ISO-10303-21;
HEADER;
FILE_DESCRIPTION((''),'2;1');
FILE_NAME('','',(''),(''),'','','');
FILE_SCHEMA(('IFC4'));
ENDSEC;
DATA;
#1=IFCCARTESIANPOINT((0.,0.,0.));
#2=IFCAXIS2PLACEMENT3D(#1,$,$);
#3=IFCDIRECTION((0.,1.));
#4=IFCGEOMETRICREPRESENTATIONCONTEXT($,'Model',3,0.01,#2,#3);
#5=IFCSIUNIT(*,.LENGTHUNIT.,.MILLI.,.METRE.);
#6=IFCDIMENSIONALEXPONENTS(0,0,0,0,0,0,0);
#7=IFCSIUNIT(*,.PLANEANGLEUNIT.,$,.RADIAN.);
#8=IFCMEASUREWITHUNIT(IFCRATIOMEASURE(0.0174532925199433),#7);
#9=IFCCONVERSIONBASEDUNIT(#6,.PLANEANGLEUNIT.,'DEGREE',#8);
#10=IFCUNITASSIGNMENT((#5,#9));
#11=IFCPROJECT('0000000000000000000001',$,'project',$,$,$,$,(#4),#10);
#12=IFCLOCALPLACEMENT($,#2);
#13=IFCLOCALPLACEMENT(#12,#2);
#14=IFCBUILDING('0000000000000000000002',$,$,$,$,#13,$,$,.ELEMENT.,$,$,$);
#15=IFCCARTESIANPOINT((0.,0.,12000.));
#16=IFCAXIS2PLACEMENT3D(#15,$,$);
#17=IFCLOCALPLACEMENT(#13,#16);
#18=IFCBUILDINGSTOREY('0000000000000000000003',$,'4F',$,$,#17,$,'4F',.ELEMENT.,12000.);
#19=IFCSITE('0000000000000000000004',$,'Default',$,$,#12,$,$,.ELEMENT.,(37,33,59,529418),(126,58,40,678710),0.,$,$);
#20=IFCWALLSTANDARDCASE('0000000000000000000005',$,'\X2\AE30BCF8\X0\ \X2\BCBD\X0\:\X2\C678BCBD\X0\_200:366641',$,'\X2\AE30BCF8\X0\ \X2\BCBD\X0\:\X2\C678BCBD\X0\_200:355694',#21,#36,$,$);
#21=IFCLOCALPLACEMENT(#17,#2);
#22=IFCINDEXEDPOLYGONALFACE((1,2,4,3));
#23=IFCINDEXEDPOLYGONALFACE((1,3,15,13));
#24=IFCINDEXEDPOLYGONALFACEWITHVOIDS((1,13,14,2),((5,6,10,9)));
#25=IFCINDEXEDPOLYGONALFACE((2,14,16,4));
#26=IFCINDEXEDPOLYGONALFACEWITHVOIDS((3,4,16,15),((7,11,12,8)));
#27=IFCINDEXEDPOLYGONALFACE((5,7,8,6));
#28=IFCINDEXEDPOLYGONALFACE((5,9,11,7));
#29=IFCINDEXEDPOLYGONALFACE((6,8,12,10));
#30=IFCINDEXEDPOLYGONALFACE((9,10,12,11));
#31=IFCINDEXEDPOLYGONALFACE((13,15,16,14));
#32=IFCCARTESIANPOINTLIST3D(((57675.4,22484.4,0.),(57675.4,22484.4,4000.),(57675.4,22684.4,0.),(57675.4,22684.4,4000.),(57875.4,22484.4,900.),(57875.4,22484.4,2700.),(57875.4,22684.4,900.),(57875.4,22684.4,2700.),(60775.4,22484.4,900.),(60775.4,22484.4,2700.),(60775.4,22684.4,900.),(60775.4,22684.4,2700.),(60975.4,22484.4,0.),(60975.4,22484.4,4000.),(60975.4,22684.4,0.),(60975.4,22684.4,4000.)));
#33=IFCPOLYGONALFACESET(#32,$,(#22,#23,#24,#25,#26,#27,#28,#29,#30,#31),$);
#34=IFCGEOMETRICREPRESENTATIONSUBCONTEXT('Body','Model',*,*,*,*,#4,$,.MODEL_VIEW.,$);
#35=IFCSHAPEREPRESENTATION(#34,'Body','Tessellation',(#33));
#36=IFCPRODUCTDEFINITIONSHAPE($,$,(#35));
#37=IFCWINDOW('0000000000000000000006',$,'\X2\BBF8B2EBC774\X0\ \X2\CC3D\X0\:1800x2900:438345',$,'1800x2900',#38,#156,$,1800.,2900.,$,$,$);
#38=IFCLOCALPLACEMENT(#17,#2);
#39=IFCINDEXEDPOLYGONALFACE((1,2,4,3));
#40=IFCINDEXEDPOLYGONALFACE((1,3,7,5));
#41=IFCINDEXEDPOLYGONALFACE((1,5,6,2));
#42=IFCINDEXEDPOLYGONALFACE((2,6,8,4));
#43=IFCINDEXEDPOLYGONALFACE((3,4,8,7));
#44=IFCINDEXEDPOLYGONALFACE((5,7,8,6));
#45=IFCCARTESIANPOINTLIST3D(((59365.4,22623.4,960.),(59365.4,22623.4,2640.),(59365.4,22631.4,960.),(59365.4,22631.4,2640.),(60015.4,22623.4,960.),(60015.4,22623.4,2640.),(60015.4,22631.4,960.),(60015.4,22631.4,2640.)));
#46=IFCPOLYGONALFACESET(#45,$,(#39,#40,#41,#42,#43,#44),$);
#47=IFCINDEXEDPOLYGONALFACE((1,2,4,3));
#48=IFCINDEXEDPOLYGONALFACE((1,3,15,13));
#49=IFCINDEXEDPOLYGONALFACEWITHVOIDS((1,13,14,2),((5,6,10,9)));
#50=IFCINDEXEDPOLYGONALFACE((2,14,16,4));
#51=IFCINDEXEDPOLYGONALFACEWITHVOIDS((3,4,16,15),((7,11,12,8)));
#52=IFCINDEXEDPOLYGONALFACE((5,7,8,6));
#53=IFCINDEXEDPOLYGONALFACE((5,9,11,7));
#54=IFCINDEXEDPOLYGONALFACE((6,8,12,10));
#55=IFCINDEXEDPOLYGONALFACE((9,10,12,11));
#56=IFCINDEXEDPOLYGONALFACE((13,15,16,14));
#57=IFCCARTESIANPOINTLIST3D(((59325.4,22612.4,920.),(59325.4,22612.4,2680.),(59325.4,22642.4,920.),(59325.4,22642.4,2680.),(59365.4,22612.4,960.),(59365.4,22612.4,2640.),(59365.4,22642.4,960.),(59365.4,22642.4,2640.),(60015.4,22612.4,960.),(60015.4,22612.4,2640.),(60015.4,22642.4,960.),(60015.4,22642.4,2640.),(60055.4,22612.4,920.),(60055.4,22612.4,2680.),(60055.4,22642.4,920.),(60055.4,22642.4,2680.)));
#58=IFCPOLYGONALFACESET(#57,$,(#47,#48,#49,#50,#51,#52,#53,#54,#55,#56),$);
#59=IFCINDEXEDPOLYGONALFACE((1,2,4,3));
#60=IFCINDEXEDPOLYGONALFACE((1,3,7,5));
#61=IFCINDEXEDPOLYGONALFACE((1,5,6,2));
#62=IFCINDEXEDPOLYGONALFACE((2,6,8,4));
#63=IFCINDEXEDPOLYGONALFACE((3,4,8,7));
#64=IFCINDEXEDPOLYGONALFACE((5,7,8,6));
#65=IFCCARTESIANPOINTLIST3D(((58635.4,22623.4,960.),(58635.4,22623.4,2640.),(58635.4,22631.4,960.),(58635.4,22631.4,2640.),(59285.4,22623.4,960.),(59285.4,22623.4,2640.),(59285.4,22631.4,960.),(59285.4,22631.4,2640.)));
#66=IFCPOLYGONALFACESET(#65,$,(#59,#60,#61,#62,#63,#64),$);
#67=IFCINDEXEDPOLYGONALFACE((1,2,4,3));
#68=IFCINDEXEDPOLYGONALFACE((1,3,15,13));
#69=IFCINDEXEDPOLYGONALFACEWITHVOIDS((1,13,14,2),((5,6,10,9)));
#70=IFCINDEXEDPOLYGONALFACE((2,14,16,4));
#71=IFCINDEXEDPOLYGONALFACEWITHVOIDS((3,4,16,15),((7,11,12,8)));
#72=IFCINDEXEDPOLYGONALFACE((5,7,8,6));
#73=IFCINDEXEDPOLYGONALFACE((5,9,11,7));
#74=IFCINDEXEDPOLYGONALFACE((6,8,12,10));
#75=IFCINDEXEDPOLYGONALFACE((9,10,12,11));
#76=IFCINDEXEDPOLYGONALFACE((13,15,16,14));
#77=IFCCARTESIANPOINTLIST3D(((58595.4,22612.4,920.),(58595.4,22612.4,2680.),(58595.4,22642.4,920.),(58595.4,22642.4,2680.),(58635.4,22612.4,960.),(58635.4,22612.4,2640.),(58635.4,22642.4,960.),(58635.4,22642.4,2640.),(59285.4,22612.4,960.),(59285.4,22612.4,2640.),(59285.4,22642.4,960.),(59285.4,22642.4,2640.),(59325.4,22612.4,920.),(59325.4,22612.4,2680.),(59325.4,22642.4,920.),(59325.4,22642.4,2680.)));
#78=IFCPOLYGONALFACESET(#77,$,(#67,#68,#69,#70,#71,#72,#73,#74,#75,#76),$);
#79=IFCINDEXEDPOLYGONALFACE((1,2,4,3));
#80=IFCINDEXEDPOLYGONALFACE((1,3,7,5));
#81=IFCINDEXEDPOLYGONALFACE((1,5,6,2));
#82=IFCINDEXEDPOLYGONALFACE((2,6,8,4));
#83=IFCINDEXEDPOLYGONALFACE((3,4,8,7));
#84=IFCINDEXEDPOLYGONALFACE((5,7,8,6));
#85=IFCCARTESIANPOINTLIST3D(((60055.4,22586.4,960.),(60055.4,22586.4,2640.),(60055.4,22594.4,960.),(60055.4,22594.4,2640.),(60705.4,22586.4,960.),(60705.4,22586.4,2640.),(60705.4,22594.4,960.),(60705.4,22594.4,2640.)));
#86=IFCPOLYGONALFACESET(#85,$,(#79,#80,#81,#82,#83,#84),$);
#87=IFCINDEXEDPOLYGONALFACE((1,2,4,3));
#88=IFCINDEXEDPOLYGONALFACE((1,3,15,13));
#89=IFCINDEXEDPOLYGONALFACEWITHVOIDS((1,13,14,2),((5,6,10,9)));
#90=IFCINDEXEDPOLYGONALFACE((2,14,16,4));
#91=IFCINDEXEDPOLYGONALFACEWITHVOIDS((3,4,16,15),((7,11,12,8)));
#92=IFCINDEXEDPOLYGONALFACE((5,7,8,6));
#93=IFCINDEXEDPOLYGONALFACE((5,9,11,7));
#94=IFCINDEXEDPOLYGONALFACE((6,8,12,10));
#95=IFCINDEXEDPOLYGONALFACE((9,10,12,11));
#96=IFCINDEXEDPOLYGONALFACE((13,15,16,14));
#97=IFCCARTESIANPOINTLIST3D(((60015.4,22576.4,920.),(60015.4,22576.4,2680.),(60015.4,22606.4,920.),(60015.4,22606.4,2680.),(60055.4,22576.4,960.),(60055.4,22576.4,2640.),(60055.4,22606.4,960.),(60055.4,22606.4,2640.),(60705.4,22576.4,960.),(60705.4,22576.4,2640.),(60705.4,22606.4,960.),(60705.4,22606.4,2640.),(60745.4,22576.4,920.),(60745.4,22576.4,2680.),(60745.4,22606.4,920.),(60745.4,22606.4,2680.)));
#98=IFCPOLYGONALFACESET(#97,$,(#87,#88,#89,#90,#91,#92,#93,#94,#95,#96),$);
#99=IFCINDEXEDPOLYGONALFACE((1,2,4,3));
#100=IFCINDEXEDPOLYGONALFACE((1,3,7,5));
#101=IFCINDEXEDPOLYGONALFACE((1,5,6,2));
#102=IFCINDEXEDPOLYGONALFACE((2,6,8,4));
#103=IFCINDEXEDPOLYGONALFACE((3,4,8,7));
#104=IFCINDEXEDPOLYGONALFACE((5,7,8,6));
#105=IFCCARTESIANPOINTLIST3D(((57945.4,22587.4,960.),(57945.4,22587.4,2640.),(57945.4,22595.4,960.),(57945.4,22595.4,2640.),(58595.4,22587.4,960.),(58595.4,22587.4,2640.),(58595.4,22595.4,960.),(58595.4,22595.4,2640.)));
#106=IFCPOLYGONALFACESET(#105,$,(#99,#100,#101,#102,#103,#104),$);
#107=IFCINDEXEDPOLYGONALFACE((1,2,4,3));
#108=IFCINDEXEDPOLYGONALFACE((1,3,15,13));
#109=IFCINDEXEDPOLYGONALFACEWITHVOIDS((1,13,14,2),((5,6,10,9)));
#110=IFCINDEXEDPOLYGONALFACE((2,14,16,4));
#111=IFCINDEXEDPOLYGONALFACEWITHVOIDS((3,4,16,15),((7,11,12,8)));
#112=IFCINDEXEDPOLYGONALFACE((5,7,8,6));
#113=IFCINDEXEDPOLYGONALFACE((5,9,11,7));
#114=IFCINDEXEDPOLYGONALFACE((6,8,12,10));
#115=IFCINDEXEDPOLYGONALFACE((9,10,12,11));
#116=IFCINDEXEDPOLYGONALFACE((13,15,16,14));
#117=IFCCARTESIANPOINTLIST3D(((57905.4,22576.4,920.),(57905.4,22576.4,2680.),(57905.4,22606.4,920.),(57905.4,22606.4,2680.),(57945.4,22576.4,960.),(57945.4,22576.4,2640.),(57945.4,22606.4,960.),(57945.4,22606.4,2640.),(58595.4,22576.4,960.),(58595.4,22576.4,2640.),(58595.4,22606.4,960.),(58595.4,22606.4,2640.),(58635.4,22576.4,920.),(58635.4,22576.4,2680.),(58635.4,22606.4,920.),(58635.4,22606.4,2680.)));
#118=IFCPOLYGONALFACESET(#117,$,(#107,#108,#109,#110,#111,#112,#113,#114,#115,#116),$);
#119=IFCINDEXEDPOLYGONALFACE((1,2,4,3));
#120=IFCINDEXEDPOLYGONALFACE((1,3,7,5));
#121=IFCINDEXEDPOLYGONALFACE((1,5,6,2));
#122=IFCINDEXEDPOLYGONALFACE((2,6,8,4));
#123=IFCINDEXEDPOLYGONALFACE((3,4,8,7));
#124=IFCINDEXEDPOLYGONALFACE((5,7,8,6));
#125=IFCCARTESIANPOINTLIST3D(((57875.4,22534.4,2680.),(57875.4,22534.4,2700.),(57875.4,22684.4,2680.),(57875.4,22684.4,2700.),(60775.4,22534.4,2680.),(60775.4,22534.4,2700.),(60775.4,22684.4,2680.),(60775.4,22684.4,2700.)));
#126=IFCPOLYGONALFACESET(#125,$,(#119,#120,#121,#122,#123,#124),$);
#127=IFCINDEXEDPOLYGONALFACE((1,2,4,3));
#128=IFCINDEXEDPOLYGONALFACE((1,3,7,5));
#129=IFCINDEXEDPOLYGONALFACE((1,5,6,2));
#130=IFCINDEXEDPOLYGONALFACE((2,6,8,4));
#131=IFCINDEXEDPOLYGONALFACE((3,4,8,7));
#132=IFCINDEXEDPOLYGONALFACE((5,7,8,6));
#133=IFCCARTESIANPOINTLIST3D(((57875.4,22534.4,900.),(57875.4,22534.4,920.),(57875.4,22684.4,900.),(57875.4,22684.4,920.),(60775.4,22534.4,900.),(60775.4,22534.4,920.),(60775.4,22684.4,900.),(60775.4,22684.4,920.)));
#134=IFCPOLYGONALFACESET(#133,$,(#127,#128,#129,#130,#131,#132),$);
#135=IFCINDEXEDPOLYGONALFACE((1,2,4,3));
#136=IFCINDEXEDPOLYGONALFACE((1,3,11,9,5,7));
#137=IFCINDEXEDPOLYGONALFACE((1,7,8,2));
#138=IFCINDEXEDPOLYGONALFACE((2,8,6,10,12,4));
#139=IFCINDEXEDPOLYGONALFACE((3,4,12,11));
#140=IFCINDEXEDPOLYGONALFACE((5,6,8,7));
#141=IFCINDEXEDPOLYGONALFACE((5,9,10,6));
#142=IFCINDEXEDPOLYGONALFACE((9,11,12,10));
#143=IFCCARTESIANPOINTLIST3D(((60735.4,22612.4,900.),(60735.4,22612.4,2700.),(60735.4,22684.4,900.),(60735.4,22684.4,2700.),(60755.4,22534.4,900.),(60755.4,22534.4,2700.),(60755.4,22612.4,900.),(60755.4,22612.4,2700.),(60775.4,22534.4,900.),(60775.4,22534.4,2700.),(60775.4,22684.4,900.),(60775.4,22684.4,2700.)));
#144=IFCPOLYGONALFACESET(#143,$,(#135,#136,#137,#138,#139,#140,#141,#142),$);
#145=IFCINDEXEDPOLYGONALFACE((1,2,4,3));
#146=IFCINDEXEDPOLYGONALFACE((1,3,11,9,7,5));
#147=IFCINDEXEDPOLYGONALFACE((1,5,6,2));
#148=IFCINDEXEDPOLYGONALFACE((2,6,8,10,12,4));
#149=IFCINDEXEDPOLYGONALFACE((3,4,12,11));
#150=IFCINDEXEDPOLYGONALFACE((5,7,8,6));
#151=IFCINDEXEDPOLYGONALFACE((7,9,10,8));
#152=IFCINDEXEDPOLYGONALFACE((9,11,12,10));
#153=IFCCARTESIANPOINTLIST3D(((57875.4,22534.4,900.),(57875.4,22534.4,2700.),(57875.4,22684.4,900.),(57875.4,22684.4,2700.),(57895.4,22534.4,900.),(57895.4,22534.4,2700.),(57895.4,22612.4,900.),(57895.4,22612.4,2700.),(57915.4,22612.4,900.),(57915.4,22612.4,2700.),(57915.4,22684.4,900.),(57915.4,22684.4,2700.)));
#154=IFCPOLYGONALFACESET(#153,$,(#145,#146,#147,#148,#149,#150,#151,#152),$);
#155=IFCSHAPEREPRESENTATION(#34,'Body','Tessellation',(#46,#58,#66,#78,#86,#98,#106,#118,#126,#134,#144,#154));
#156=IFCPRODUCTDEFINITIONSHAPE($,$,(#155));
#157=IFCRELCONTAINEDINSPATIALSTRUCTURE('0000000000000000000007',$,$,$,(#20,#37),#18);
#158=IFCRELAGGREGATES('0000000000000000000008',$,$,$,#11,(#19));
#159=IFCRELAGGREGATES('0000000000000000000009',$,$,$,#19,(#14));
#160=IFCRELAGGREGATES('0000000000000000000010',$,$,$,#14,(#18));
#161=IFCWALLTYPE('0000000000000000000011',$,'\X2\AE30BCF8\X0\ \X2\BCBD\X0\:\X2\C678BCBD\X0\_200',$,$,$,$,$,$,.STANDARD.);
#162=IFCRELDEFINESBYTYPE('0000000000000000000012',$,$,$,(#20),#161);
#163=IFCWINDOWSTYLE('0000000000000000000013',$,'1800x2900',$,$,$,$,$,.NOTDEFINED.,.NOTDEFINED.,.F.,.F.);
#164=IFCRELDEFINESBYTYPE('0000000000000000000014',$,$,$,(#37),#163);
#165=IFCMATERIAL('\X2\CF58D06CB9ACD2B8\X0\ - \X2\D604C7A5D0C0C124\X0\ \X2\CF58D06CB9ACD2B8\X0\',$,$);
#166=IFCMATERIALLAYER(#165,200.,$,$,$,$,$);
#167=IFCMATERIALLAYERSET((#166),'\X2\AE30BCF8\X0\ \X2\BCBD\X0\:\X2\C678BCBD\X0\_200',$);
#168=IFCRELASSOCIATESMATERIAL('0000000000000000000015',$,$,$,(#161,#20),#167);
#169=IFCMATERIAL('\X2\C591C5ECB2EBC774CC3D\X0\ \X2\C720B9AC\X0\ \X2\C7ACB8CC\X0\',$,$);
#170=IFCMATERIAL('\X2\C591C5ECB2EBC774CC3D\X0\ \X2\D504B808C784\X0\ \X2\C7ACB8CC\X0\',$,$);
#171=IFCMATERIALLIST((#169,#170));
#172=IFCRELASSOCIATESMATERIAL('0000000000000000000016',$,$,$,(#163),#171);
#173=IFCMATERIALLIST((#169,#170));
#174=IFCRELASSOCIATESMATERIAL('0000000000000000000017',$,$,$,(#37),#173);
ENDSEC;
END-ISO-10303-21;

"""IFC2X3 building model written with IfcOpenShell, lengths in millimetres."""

from ifc_helpers import new_model, entity, si_unit, converted_unit, direction, frame, frame_2d, origin, origin_2d_with_axis, place, context, subcontext, project, spatial, polyline, rectangle, outline, extrude, source, transform, mapped, material, material_list, layer, layer_set, layer_usage, type_object, type_shapes, element, fill, save


model = new_model("IFC2X3")

# Units and contexts
model_context = context("Model", 3, precision=0.01, world=origin(), true_north=direction((0.0, 1.0)))
body_context = subcontext(model_context, "Body", "Model", "MODEL_VIEW")
ifc_project = project(units=[si_unit("LENGTHUNIT", "METRE", prefix="MILLI"), converted_unit("PLANEANGLEUNIT", "DEGREE", entity("IfcRatioMeasure", 0.0174532925199433), si_unit("PLANEANGLEUNIT", "RADIAN"), dimensions=[0, 0, 0, 0, 0, 0, 0])], contexts=[model_context])

# Site, building, storey
site_placement = place(None, origin())
site = spatial("IfcSite", under=ifc_project, at=site_placement, Name="Default", CompositionType="ELEMENT", RefLatitude=(37, 33, 59, 529418), RefLongitude=(126, 58, 40, 678710), RefElevation=0.0)
building_placement = place(site_placement, origin())
building = spatial("IfcBuilding", under=site, at=building_placement, CompositionType="ELEMENT")
storey_placement = place(building_placement, frame((0.0, 0.0, 12000.0)))
storey = spatial("IfcBuildingStorey", under=building, at=storey_placement, Name="4F", LongName="4F", CompositionType="ELEMENT", Elevation=12000.0)

# Wall, opening, window
ifc_material_1 = material(Name="콘크리트 - 현장타설 콘크리트")
ifc_layer_1 = layer(ifc_material_1, 200.0)
ifc_layer_set_1 = layer_set([ifc_layer_1], Name="기본 벽:외벽_200")
wall_type_1 = type_object("IfcWallType", Name="기본 벽:외벽_200", PredefinedType="STANDARD", material=ifc_layer_set_1)
ifc_material_2 = material(Name="양여닫이창 유리 재료")
ifc_material_3 = material(Name="양여닫이창 프레임 재료")
ifc_material_list_1 = material_list([ifc_material_2, ifc_material_3])
window_style = type_object("IfcWindowStyle", Name="1800x2900", ConstructionType="NOTDEFINED", OperationType="NOTDEFINED", ParameterTakesPrecedence=False, Sizeable=False, material=ifc_material_list_1)
shared_shape_1 = source(origin(), body_context, "Body", "SweptSolid", [
    extrude(rectangle(XDim=8.0, YDim=650.0, at=frame_2d((0.0, 0.0), x_axis=(1.0, 0.0))), frame((1815.0, 143.0, 60.0), z_axis=(0.0, 0.0, 1.0), x_axis=(0.0, 1.0, 0.0)), (0.0, 0.0, 1.0), 1680.0),
    extrude(outline(polyline([(-880.0, -365.0), (880.0, -365.0), (880.0, 365.0), (-880.0, 365.0), (-880.0, -365.0)]), holes=[polyline([(840.0, -325.0), (-840.0, -325.0), (-840.0, 325.0), (840.0, 325.0), (840.0, -325.0)])]), frame((1815.0, 128.0, 900.0), z_axis=(0.0, 1.0, 0.0), x_axis=(0.0, 0.0, -1.0)), (0.0, 0.0, 1.0), 30.0),
    extrude(rectangle(XDim=8.0, YDim=650.0, at=frame_2d((0.0, 0.0), x_axis=(1.0, 0.0))), frame((1085.0, 143.0, 60.0), z_axis=(0.0, 0.0, 1.0), x_axis=(0.0, 1.0, 0.0)), (0.0, 0.0, 1.0), 1680.0),
    extrude(outline(polyline([(-880.0, -365.0), (880.0, -365.0), (880.0, 365.0), (-880.0, 365.0), (-880.0, -365.0)]), holes=[polyline([(840.0, -325.0), (-840.0, -325.0), (-840.0, 325.0), (840.0, 325.0), (840.0, -325.0)])]), frame((1085.0, 128.0, 900.0), z_axis=(0.0, 1.0, 0.0), x_axis=(0.0, 0.0, -1.0)), (0.0, 0.0, 1.0), 30.0),
    extrude(rectangle(XDim=8.0, YDim=650.0, at=frame_2d((0.0, 0.0), x_axis=(1.0, 0.0))), frame((2505.0, 106.0, 60.0), z_axis=(0.0, 0.0, 1.0), x_axis=(0.0, 1.0, 0.0)), (0.0, 0.0, 1.0), 1680.0),
    extrude(outline(polyline([(-880.0, -365.0), (880.0, -365.0), (880.0, 365.0), (-880.0, 365.0), (-880.0, -365.0)]), holes=[polyline([(840.0, -325.0), (-840.0, -325.0), (-840.0, 325.0), (840.0, 325.0), (840.0, -325.0)])]), frame((2505.0, 92.0, 900.0), z_axis=(0.0, 1.0, 0.0), x_axis=(0.0, 0.0, -1.0)), (0.0, 0.0, 1.0), 30.0),
    extrude(rectangle(XDim=8.0, YDim=650.0, at=origin_2d_with_axis()), frame((395.0, 107.0, 60.0), z_axis=(0.0, 0.0, 1.0), x_axis=(0.0, 1.0, 0.0)), (0.0, 0.0, 1.0), 1680.0),
    extrude(outline(polyline([(-880.0, -365.0), (880.0, -365.0), (880.0, 365.0), (-880.0, 365.0), (-880.0, -365.0)]), holes=[polyline([(840.0, -325.0), (-840.0, -325.0), (-840.0, 325.0), (840.0, 325.0), (840.0, -325.0)])]), frame((395.0, 92.0, 900.0), z_axis=(0.0, 1.0, 0.0), x_axis=(0.0, 0.0, -1.0)), (0.0, 0.0, 1.0), 30.0),
    extrude(rectangle(XDim=2900.0, YDim=150.0, at=origin_2d_with_axis()), frame((1450.0, 125.0, 1780.0), z_axis=(0.0, 0.0, 1.0), x_axis=(-1.0, 0.0, 0.0)), (0.0, 0.0, 1.0), 20.0),
    extrude(rectangle(XDim=2900.0, YDim=150.0, at=origin_2d_with_axis()), frame((1450.0, 125.0, 0.0), z_axis=(0.0, 0.0, 1.0), x_axis=(-1.0, 0.0, 0.0)), (0.0, 0.0, 1.0), 20.0),
    extrude(outline(polyline([(-74.0, -20.0), (-2.0, -20.0), (-2.0, 0.0), (76.0, 0.0), (76.0, 20.0), (-74.0, 20.0), (-74.0, -20.0)])), frame((2880.0, 126.0, 0.0), z_axis=(0.0, 0.0, 1.0), x_axis=(0.0, -1.0, 0.0)), (0.0, 0.0, 1.0), 1800.0),
    extrude(outline(polyline([(-20.0, -74.0), (20.0, -74.0), (20.0, 76.0), (0.0, 76.0), (0.0, -2.0), (-20.0, -2.0), (-20.0, -74.0)])), frame((20.0, 126.0, 0.0), z_axis=(0.0, 0.0, 1.0), x_axis=(-1.0, 0.0, 0.0)), (0.0, 0.0, 1.0), 1800.0),
])
type_shapes(window_style, [shared_shape_1])
ifc_layer_usage_1 = layer_usage(ifc_layer_set_1, "AXIS2", "NEGATIVE", 100.0)
wall_1_placement = place(storey_placement, frame((60975.4, 22584.4, 0.0), z_axis=(0.0, 0.0, 1.0), x_axis=(-1.0, 0.0, 0.0)))
wall_1 = element("IfcWallStandardCase", 1, at=wall_1_placement, inside=storey, type_object=wall_type_1, material=ifc_layer_usage_1, Name="기본 벽:외벽_200:366641", ObjectType="기본 벽:외벽_200:355694", context=body_context, shape_type="SweptSolid", body=[
    extrude(rectangle(XDim=3300.0, YDim=200.0, at=frame_2d((1650.0, 0.0), x_axis=(-1.0, 0.0))), origin(), (0.0, 0.0, 1.0), 4000.0),
])
opening_1_placement = place(wall_1_placement, frame((3100.0, 100.0, 900.0)))
opening_1 = element("IfcOpeningElement", 2, at=opening_1_placement, cuts=wall_1, ObjectType="Opening", context=body_context, shape_type="SweptSolid", body=[
    extrude(rectangle(XDim=1800.0, YDim=2900.0, at=frame_2d((900.0, 1450.0), x_axis=(1.0, 0.0))), frame((0.0, 0.0, 0.0), z_axis=(0.0, -1.0, 0.0), x_axis=(0.0, 0.0, 1.0)), (0.0, 0.0, 1.0), 200.0),
])
ifc_material_list_2 = material_list([ifc_material_2, ifc_material_3])
window_1_placement = place(opening_1_placement, frame((0.0, 0.0, 0.0), z_axis=(0.0, 0.0, 1.0), x_axis=(-1.0, 0.0, 0.0)))
window_1 = element("IfcWindow", 3, at=window_1_placement, inside=storey, type_object=window_style, material=ifc_material_list_2, Name="미닫이 창:1800x2900:438345", ObjectType="1800x2900", OverallHeight=1800.0, OverallWidth=2900.0, context=body_context, shape_type="MappedRepresentation", body=[
    mapped(shared_shape_1, transform((0.0, 0.0, 0.0), scale=1.0)),
])
fill(opening_1, window_1)

save(model, "model.ifc")
